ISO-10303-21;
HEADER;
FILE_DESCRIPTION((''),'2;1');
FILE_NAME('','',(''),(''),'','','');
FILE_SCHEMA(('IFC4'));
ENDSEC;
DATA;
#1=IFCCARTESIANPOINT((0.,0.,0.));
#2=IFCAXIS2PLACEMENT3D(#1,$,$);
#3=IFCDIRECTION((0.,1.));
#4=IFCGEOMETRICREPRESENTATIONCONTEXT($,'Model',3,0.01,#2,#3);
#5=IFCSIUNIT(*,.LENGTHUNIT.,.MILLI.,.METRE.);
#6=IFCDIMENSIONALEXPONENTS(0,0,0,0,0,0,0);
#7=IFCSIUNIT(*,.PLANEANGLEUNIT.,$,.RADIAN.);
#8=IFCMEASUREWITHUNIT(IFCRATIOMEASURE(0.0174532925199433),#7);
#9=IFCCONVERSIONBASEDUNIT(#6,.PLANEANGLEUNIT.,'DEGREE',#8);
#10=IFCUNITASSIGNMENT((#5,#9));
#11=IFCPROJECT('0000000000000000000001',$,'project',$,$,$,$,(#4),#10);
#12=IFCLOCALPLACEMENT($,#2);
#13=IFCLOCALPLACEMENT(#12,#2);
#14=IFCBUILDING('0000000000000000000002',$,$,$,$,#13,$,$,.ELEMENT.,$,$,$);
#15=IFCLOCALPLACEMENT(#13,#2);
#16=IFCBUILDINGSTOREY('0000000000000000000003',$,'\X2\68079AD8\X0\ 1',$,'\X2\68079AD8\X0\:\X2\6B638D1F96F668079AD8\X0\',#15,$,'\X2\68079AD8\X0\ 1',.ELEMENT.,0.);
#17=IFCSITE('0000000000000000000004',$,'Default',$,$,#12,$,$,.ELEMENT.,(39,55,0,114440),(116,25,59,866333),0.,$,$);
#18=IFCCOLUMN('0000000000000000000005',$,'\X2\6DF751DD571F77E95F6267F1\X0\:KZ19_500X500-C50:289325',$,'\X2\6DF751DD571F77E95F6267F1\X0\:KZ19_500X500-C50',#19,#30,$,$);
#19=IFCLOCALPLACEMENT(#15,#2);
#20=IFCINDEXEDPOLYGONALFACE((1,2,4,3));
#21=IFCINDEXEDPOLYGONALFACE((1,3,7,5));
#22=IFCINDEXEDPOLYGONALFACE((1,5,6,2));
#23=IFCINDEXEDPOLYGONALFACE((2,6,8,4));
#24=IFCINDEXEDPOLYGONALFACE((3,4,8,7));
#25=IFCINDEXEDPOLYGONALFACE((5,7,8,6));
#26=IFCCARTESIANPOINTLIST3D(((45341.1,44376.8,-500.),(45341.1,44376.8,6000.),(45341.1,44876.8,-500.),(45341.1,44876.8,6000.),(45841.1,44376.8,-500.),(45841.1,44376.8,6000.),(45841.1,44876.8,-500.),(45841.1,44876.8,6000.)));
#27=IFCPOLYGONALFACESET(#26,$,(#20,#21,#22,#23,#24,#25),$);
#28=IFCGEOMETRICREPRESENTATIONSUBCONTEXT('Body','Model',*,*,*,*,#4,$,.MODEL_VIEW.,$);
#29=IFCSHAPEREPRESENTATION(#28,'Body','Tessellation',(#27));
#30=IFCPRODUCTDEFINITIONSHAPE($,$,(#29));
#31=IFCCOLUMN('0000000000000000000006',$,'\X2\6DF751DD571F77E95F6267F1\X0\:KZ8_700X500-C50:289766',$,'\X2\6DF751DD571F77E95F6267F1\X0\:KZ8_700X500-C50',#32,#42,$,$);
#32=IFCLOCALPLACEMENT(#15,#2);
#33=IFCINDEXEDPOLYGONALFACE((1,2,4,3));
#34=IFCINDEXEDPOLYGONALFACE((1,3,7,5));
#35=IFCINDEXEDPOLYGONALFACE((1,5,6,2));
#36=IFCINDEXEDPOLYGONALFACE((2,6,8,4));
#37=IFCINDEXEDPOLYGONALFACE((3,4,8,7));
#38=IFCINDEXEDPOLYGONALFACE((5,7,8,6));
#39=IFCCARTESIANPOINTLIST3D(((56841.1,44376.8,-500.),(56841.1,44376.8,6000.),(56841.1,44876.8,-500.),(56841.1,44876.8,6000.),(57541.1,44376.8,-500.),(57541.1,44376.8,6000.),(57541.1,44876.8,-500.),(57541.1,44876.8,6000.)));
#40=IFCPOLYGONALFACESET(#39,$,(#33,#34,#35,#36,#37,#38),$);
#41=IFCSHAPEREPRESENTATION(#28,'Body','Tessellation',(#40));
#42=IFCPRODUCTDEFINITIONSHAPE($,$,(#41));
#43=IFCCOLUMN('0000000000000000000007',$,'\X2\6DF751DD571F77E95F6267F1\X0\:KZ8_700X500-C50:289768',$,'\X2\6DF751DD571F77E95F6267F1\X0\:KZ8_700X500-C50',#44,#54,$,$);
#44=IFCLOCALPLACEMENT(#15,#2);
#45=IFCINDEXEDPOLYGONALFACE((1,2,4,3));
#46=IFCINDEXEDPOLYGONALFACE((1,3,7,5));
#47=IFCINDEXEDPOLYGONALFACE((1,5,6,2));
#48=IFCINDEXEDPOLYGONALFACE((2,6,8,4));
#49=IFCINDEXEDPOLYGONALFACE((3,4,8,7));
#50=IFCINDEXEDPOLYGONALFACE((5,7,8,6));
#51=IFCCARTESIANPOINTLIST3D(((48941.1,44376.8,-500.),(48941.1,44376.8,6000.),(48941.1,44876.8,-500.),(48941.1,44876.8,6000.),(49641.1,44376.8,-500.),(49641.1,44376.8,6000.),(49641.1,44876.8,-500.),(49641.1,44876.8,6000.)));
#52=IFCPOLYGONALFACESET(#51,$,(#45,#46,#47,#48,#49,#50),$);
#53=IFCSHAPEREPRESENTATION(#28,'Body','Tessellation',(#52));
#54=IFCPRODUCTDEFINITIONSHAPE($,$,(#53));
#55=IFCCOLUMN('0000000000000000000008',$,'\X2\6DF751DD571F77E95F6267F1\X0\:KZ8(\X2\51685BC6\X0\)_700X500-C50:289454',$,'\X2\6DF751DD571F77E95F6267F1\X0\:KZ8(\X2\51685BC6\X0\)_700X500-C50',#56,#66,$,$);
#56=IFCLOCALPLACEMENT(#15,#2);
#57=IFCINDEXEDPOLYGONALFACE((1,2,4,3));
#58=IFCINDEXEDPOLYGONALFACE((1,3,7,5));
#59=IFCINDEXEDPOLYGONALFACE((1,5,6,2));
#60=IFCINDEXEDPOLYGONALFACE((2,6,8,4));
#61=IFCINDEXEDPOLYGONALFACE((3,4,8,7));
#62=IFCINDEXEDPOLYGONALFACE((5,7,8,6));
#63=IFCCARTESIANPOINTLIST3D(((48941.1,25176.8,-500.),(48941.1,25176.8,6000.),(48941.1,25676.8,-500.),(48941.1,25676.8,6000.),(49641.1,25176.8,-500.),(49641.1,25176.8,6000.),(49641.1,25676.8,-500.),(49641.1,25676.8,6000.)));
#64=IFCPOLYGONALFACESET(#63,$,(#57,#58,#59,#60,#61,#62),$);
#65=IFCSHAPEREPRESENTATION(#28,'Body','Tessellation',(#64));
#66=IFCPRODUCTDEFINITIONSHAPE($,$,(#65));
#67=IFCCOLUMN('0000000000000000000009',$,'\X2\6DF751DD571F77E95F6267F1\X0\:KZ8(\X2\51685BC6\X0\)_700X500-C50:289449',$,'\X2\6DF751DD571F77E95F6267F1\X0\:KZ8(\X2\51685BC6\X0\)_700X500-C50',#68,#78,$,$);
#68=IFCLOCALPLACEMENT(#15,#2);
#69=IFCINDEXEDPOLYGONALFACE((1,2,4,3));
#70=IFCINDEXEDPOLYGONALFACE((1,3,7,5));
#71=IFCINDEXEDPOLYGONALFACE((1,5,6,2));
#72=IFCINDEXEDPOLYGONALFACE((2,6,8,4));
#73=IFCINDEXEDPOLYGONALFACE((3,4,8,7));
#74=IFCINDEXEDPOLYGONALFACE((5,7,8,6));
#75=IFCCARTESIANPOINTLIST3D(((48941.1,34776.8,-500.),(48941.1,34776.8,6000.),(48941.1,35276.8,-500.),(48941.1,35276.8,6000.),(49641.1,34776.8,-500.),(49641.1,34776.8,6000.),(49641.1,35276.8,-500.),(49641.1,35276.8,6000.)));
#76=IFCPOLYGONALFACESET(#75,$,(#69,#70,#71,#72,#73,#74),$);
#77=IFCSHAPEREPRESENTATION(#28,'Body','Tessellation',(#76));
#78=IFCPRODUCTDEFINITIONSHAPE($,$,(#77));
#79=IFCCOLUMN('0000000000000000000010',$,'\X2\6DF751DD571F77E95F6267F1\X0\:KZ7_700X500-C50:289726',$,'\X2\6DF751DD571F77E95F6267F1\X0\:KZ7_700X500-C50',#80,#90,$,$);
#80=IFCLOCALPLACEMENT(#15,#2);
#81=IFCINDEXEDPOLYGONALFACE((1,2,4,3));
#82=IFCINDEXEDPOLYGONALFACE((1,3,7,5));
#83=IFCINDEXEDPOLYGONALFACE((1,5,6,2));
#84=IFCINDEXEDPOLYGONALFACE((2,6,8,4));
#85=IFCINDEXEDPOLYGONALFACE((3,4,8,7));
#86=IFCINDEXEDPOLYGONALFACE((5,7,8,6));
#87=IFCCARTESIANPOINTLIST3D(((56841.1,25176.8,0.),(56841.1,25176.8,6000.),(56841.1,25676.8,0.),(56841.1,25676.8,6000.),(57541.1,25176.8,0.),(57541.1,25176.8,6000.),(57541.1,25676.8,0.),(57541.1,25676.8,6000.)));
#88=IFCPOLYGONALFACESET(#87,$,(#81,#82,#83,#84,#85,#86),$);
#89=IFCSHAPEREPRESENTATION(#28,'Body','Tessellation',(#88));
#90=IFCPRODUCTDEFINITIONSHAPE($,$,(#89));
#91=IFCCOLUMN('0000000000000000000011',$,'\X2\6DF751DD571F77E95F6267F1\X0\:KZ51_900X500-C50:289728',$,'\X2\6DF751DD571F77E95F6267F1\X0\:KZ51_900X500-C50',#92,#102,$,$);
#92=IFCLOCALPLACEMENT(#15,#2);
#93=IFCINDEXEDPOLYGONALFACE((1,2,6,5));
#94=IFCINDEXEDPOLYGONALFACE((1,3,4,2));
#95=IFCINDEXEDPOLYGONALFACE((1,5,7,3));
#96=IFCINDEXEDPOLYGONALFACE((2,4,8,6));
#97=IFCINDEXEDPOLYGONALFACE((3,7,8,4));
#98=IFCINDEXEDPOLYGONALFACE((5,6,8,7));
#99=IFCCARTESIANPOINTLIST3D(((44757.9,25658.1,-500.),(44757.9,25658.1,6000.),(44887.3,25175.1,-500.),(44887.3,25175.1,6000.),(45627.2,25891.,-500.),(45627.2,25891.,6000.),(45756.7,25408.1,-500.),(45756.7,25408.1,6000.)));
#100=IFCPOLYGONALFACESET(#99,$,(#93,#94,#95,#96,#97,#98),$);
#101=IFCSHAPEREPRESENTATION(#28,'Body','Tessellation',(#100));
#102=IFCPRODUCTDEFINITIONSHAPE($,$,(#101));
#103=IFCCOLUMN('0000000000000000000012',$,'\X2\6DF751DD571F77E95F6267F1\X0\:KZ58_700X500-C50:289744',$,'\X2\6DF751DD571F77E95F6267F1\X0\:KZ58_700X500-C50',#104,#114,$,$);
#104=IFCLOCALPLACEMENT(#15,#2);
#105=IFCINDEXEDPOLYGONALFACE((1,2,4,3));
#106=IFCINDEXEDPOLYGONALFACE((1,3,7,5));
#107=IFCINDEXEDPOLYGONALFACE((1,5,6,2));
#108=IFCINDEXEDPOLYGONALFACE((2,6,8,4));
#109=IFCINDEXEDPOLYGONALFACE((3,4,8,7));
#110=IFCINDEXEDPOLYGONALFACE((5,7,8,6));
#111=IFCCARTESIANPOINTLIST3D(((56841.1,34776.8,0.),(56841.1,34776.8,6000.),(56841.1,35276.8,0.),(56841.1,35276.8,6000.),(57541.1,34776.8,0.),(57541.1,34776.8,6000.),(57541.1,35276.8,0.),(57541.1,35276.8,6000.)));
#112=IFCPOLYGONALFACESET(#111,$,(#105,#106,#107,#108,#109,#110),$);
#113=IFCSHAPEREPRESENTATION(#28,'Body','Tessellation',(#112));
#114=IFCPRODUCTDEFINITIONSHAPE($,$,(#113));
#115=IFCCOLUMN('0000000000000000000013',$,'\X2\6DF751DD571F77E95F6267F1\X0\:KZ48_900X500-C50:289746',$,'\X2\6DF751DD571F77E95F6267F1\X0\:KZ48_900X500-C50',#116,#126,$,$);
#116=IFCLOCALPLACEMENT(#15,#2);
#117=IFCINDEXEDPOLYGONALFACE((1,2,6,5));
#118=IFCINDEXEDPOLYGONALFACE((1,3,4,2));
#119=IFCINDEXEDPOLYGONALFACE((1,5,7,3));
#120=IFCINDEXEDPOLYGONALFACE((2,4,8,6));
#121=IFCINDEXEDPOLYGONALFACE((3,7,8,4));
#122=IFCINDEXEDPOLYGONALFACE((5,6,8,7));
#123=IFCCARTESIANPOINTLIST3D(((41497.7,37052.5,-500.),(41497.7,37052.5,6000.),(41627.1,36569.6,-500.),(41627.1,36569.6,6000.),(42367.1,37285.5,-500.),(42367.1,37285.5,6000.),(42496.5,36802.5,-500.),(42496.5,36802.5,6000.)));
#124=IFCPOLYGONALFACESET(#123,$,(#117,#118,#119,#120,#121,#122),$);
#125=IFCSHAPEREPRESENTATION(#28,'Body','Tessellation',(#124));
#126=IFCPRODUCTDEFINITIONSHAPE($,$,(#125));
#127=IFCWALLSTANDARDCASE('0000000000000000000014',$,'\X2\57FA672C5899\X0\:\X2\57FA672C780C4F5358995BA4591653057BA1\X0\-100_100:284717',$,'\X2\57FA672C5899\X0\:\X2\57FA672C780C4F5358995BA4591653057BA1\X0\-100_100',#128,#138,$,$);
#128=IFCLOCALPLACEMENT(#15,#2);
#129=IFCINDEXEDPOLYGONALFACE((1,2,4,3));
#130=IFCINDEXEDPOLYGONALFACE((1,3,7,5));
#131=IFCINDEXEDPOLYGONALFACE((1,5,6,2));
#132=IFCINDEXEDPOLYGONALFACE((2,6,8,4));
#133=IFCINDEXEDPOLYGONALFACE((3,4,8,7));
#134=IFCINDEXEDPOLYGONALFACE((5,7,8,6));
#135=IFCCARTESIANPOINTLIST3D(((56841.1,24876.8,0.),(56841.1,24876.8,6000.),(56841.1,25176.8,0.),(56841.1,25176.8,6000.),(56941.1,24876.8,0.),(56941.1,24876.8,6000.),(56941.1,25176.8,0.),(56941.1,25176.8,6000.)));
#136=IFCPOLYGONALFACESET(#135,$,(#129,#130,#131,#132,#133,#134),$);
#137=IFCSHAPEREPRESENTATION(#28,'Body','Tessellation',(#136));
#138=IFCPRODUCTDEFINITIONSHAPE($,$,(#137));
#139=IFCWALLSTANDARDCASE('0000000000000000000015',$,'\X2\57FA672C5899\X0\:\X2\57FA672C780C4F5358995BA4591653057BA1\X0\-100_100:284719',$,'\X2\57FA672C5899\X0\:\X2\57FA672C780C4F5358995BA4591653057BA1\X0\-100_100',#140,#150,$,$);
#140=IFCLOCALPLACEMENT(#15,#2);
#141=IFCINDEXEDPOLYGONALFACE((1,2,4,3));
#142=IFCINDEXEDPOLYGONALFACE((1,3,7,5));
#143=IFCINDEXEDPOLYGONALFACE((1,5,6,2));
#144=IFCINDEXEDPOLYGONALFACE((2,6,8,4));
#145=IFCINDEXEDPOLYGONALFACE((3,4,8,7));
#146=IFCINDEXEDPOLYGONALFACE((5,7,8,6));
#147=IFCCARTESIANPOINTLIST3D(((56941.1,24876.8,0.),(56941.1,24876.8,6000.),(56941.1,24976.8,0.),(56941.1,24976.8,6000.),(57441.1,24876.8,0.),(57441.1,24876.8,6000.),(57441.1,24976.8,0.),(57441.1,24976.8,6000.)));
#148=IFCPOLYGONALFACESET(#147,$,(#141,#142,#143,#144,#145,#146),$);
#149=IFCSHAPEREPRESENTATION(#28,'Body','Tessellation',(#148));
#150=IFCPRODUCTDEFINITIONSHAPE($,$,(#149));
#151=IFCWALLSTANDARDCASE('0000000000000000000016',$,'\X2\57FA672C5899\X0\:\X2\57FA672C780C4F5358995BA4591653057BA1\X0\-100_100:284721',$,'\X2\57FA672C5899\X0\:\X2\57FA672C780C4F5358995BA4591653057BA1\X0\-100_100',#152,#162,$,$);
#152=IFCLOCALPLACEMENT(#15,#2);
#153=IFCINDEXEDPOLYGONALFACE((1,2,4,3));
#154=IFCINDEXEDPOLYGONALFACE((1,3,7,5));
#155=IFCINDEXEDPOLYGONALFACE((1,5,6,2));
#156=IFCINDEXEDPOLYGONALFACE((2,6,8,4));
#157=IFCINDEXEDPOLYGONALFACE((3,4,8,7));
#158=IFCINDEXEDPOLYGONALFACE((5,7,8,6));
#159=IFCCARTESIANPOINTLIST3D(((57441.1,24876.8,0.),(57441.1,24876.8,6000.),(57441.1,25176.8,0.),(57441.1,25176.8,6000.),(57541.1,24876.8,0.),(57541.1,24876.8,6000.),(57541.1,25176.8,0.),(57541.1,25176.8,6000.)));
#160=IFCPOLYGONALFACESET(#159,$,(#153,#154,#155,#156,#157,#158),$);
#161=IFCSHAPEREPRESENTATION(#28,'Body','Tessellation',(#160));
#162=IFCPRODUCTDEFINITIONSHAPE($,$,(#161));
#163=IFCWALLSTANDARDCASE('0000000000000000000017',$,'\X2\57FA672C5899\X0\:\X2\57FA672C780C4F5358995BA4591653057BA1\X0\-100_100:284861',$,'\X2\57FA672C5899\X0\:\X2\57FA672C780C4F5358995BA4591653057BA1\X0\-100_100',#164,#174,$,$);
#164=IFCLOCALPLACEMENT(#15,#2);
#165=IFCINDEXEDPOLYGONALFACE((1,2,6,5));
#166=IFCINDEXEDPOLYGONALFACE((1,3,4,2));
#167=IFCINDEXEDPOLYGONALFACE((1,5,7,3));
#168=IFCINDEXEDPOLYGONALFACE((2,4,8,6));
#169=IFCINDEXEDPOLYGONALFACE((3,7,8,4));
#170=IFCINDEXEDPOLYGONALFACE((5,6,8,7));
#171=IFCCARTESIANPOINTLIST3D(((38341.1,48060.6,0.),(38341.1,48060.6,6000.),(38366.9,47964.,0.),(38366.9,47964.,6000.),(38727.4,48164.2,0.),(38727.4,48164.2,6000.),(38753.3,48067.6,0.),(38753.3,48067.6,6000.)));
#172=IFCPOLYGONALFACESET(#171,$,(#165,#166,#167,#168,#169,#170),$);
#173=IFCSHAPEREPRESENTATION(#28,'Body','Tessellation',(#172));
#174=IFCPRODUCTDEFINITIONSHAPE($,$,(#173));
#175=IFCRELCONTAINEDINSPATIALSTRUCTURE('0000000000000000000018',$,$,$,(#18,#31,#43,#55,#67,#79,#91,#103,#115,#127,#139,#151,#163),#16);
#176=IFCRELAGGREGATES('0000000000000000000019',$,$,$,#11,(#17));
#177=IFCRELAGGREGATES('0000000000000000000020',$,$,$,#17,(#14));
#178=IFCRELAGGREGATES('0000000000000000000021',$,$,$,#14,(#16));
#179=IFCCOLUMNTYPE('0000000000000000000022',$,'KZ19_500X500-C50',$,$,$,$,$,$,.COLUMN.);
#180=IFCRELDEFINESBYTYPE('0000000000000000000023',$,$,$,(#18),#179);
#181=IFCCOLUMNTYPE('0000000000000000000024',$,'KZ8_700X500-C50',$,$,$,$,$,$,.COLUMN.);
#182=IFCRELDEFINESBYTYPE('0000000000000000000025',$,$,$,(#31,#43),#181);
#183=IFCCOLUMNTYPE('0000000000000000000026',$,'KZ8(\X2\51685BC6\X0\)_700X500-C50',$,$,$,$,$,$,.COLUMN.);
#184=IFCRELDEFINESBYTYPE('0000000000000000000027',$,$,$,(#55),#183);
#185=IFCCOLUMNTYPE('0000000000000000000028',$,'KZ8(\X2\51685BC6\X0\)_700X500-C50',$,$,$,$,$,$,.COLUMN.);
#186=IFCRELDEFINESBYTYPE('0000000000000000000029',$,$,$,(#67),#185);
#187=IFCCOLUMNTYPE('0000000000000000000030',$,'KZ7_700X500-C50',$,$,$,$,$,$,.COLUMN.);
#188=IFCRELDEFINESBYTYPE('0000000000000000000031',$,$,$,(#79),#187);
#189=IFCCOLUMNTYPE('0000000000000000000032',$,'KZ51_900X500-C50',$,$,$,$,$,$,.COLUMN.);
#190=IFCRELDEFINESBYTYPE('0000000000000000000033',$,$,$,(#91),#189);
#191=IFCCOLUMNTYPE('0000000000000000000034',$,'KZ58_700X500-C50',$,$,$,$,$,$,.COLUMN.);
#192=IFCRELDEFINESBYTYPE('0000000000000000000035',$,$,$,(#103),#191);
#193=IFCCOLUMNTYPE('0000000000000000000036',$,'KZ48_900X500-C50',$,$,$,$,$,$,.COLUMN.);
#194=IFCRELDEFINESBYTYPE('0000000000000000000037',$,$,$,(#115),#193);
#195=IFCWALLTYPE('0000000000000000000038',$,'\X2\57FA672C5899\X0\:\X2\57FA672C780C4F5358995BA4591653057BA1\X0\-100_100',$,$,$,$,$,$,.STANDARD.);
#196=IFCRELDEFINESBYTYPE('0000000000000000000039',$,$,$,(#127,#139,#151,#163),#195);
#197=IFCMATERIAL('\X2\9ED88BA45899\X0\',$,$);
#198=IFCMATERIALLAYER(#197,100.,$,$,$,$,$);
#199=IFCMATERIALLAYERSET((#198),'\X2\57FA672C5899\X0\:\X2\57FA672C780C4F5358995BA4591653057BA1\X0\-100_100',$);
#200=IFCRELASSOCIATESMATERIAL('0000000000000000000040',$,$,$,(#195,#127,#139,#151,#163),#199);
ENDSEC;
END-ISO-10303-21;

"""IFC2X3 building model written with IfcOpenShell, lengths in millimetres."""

from ifc_helpers import new_model, entity, si_unit, converted_unit, direction, frame, frame_2d, origin, origin_2d_with_axis, place, context, subcontext, project, spatial, rectangle, extrude, source, transform, mapped, material, layer, layer_set, layer_usage, type_object, type_shapes, element, save


model = new_model("IFC2X3")

# Units and contexts
model_context = context("Model", 3, precision=0.01, world=origin(), true_north=direction((0.0, 1.0)))
body_context = subcontext(model_context, "Body", "Model", "MODEL_VIEW")
ifc_project = project(units=[si_unit("LENGTHUNIT", "METRE", prefix="MILLI"), converted_unit("PLANEANGLEUNIT", "DEGREE", entity("IfcRatioMeasure", 0.0174532925199433), si_unit("PLANEANGLEUNIT", "RADIAN"), dimensions=[0, 0, 0, 0, 0, 0, 0])], contexts=[model_context])

# Site, building, storey
site_placement = place(None, origin())
site = spatial("IfcSite", under=ifc_project, at=site_placement, Name="Default", CompositionType="ELEMENT", RefLatitude=(39, 55, 0, 114440), RefLongitude=(116, 25, 59, 866333), RefElevation=0.0)
building_placement = place(site_placement, origin())
building = spatial("IfcBuilding", under=site, at=building_placement, CompositionType="ELEMENT")
storey_placement = place(building_placement, origin())
storey = spatial("IfcBuildingStorey", under=building, at=storey_placement, Name="标高 1", ObjectType="标高:正负零标高", LongName="标高 1", CompositionType="ELEMENT", Elevation=0.0)

# Columns
column_type_1 = type_object("IfcColumnType", Name="KZ19_500X500-C50", PredefinedType="COLUMN")
shared_shape_1 = source(origin(), body_context, "Body", "SweptSolid", [
    extrude(rectangle(XDim=500.0, YDim=500.0, at=origin_2d_with_axis()), frame((0.0, 0.0, -500.0), z_axis=(0.0, 0.0, 1.0), x_axis=(0.0, -1.0, 0.0)), (0.0, 0.0, 1.0), 6500.0),
])
type_shapes(column_type_1, [shared_shape_1])
column_1_placement = place(building_placement, frame((45591.1, 44626.8, 0.0)))
element("IfcColumn", 1, at=column_1_placement, inside=storey, type_object=column_type_1, Name="混凝土矩形柱:KZ19_500X500-C50:289325", ObjectType="混凝土矩形柱:KZ19_500X500-C50", context=body_context, shape_type="MappedRepresentation", body=[
    mapped(shared_shape_1, transform((0.0, 0.0, 0.0), scale=1.0)),
])
column_type_2 = type_object("IfcColumnType", Name="KZ8_700X500-C50", PredefinedType="COLUMN")
shared_shape_2 = source(origin(), body_context, "Body", "SweptSolid", [
    extrude(rectangle(XDim=500.0, YDim=700.0, at=origin_2d_with_axis()), frame((0.0, 0.0, -500.0), z_axis=(0.0, 0.0, 1.0), x_axis=(0.0, -1.0, 0.0)), (0.0, 0.0, 1.0), 6500.0),
])
type_shapes(column_type_2, [shared_shape_2])
for number, where, name in (
    (2, (57191.1, 44626.8, 0.0), "混凝土矩形柱:KZ8_700X500-C50:289766"),
    (3, (49291.1, 44626.8, 0.0), "混凝土矩形柱:KZ8_700X500-C50:289768"),
):
    element("IfcColumn", number, at=place(building_placement, frame(where)), inside=storey, type_object=column_type_2, Name=name, ObjectType="混凝土矩形柱:KZ8_700X500-C50", context=body_context, shape_type="MappedRepresentation", body=[
        mapped(shared_shape_2, transform((0.0, 0.0, 0.0), scale=1.0)),
    ])
column_type_3 = type_object("IfcColumnType", Name="KZ8(全密)_700X500-C50", PredefinedType="COLUMN")
shared_shape_3 = source(origin(), body_context, "Body", "SweptSolid", [
    extrude(rectangle(XDim=500.0, YDim=700.0, at=origin_2d_with_axis()), frame((0.0, 0.0, -500.0), z_axis=(0.0, 0.0, 1.0), x_axis=(0.0, -1.0, 0.0)), (0.0, 0.0, 1.0), 6500.0),
])
type_shapes(column_type_3, [shared_shape_3])
column_2_placement = place(building_placement, frame((49291.1, 25426.8, 0.0)))
element("IfcColumn", 4, at=column_2_placement, inside=storey, type_object=column_type_3, Name="混凝土矩形柱:KZ8(全密)_700X500-C50:289454", ObjectType="混凝土矩形柱:KZ8(全密)_700X500-C50", context=body_context, shape_type="MappedRepresentation", body=[
    mapped(shared_shape_3, transform((0.0, 0.0, 0.0), scale=1.0)),
])
column_type_4 = type_object("IfcColumnType", Name="KZ8(全密)_700X500-C50", PredefinedType="COLUMN")
shared_shape_4 = source(origin(), body_context, "Body", "SweptSolid", [
    extrude(rectangle(XDim=500.0, YDim=700.0, at=origin_2d_with_axis()), frame((0.0, 0.0, -500.0), z_axis=(0.0, 0.0, 1.0), x_axis=(0.0, -1.0, 0.0)), (0.0, 0.0, 1.0), 6500.0),
])
type_shapes(column_type_4, [shared_shape_4])
column_3_placement = place(building_placement, frame((49291.1, 35026.8, 0.0), z_axis=(0.0, 0.0, 1.0), x_axis=(-1.0, 0.0, 0.0)))
element("IfcColumn", 5, at=column_3_placement, inside=storey, type_object=column_type_4, Name="混凝土矩形柱:KZ8(全密)_700X500-C50:289449", ObjectType="混凝土矩形柱:KZ8(全密)_700X500-C50", context=body_context, shape_type="MappedRepresentation", body=[
    mapped(shared_shape_4, transform((0.0, 0.0, 0.0), scale=1.0)),
])
column_type_5 = type_object("IfcColumnType", Name="KZ7_700X500-C50", PredefinedType="COLUMN")
shared_shape_5 = source(origin(), body_context, "Body", "SweptSolid", [
    extrude(rectangle(XDim=500.0, YDim=700.0, at=origin_2d_with_axis()), frame((0.0, 0.0, 0.0), z_axis=(0.0, 0.0, 1.0), x_axis=(0.0, -1.0, 0.0)), (0.0, 0.0, 1.0), 6000.0),
])
type_shapes(column_type_5, [shared_shape_5])
column_4_placement = place(building_placement, frame((57191.1, 25426.8, 0.0)))
element("IfcColumn", 6, at=column_4_placement, inside=storey, type_object=column_type_5, Name="混凝土矩形柱:KZ7_700X500-C50:289726", ObjectType="混凝土矩形柱:KZ7_700X500-C50", context=body_context, shape_type="MappedRepresentation", body=[
    mapped(shared_shape_5, transform((0.0, 0.0, 0.0), scale=1.0)),
])
column_type_6 = type_object("IfcColumnType", Name="KZ51_900X500-C50", PredefinedType="COLUMN")
shared_shape_6 = source(origin(), body_context, "Body", "SweptSolid", [
    extrude(rectangle(XDim=500.0, YDim=900.0, at=origin_2d_with_axis()), frame((0.0, 0.0, -500.0), z_axis=(0.0, 0.0, 1.0), x_axis=(0.0, -1.0, 0.0)), (0.0, 0.0, 1.0), 6500.0),
])
type_shapes(column_type_6, [shared_shape_6])
column_5_placement = place(building_placement, frame((45257.3, 25533.1, 0.0), z_axis=(0.0, 0.0, 1.0), x_axis=(0.965926, 0.258819, 0.0)))
element("IfcColumn", 7, at=column_5_placement, inside=storey, type_object=column_type_6, Name="混凝土矩形柱:KZ51_900X500-C50:289728", ObjectType="混凝土矩形柱:KZ51_900X500-C50", context=body_context, shape_type="MappedRepresentation", body=[
    mapped(shared_shape_6, transform((0.0, 0.0, 0.0), scale=1.0)),
])
column_type_7 = type_object("IfcColumnType", Name="KZ58_700X500-C50", PredefinedType="COLUMN")
shared_shape_7 = source(origin(), body_context, "Body", "SweptSolid", [
    extrude(rectangle(XDim=500.0, YDim=700.0, at=origin_2d_with_axis()), frame((0.0, 0.0, 0.0), z_axis=(0.0, 0.0, 1.0), x_axis=(0.0, -1.0, 0.0)), (0.0, 0.0, 1.0), 6000.0),
])
type_shapes(column_type_7, [shared_shape_7])
column_6_placement = place(building_placement, frame((57191.1, 35026.8, 0.0)))
element("IfcColumn", 8, at=column_6_placement, inside=storey, type_object=column_type_7, Name="混凝土矩形柱:KZ58_700X500-C50:289744", ObjectType="混凝土矩形柱:KZ58_700X500-C50", context=body_context, shape_type="MappedRepresentation", body=[
    mapped(shared_shape_7, transform((0.0, 0.0, 0.0), scale=1.0)),
])
column_type_8 = type_object("IfcColumnType", Name="KZ48_900X500-C50", PredefinedType="COLUMN")
shared_shape_8 = source(origin(), body_context, "Body", "SweptSolid", [
    extrude(rectangle(XDim=500.0, YDim=900.0, at=origin_2d_with_axis()), frame((0.0, 0.0, -500.0), z_axis=(0.0, 0.0, 1.0), x_axis=(0.0, -1.0, 0.0)), (0.0, 0.0, 1.0), 6500.0),
])
type_shapes(column_type_8, [shared_shape_8])
column_7_placement = place(building_placement, frame((41997.1, 36927.5, 0.0), z_axis=(0.0, 0.0, 1.0), x_axis=(0.965926, 0.258819, 0.0)))
element("IfcColumn", 9, at=column_7_placement, inside=storey, type_object=column_type_8, Name="混凝土矩形柱:KZ48_900X500-C50:289746", ObjectType="混凝土矩形柱:KZ48_900X500-C50", context=body_context, shape_type="MappedRepresentation", body=[
    mapped(shared_shape_8, transform((0.0, 0.0, 0.0), scale=1.0)),
])

# Walls
ifc_material = material(Name="默认墙")
ifc_layer_1 = layer(ifc_material, 100.0)
ifc_layer_set_1 = layer_set([ifc_layer_1], Name="基本墙:基本砌体墙室外包管-100_100")
ifc_layer_usage_1 = layer_usage(ifc_layer_set_1, "AXIS2", "NEGATIVE", 50.0)
wall_type_1 = type_object("IfcWallType", Name="基本墙:基本砌体墙室外包管-100_100", PredefinedType="STANDARD", material=ifc_layer_set_1)
wall_1_placement = place(building_placement, frame((56891.1, 24876.8, 0.0), z_axis=(0.0, 0.0, 1.0), x_axis=(0.0, 1.0, 0.0)))
element("IfcWallStandardCase", 10, at=wall_1_placement, inside=storey, type_object=wall_type_1, material=ifc_layer_usage_1, Name="基本墙:基本砌体墙室外包管-100_100:284717", ObjectType="基本墙:基本砌体墙室外包管-100_100", context=body_context, shape_type="SweptSolid", body=[
    extrude(rectangle(XDim=300.0, YDim=100.0, at=frame_2d((150.0, 0.0), x_axis=(-1.0, 0.0))), origin(), (0.0, 0.0, 1.0), 6000.0),
])
ifc_layer_usage_2 = layer_usage(ifc_layer_set_1, "AXIS2", "NEGATIVE", 50.0)
wall_2_placement = place(building_placement, frame((57441.1, 24926.8, 0.0), z_axis=(0.0, 0.0, 1.0), x_axis=(-1.0, 0.0, 0.0)))
element("IfcWallStandardCase", 11, at=wall_2_placement, inside=storey, type_object=wall_type_1, material=ifc_layer_usage_2, Name="基本墙:基本砌体墙室外包管-100_100:284719", ObjectType="基本墙:基本砌体墙室外包管-100_100", context=body_context, shape_type="SweptSolid", body=[
    extrude(rectangle(XDim=500.0, YDim=100.0, at=frame_2d((250.0, 0.0), x_axis=(-1.0, 0.0))), origin(), (0.0, 0.0, 1.0), 6000.0),
])
ifc_layer_usage_3 = layer_usage(ifc_layer_set_1, "AXIS2", "NEGATIVE", 50.0)
wall_3_placement = place(building_placement, frame((57491.1, 24876.8, 0.0), z_axis=(0.0, 0.0, 1.0), x_axis=(0.0, 1.0, 0.0)))
element("IfcWallStandardCase", 12, at=wall_3_placement, inside=storey, type_object=wall_type_1, material=ifc_layer_usage_3, Name="基本墙:基本砌体墙室外包管-100_100:284721", ObjectType="基本墙:基本砌体墙室外包管-100_100", context=body_context, shape_type="SweptSolid", body=[
    extrude(rectangle(XDim=300.0, YDim=100.0, at=frame_2d((150.0, 0.0), x_axis=(-1.0, 0.0))), origin(), (0.0, 0.0, 1.0), 6000.0),
])
ifc_layer_usage_4 = layer_usage(ifc_layer_set_1, "AXIS2", "NEGATIVE", 50.0)
wall_4_placement = place(building_placement, frame((38354.0, 48012.3, 0.0), z_axis=(0.0, 0.0, 1.0), x_axis=(0.965926, 0.258819, 0.0)))
element("IfcWallStandardCase", 13, at=wall_4_placement, inside=storey, type_object=wall_type_1, material=ifc_layer_usage_4, Name="基本墙:基本砌体墙室外包管-100_100:284861", ObjectType="基本墙:基本砌体墙室外包管-100_100", context=body_context, shape_type="SweptSolid", body=[
    extrude(rectangle(XDim=400.0, YDim=100.0, at=frame_2d((200.0, 0.0), x_axis=(-1.0, 0.0))), origin(), (0.0, 0.0, 1.0), 6000.0),
])

save(model, "model.ifc")
